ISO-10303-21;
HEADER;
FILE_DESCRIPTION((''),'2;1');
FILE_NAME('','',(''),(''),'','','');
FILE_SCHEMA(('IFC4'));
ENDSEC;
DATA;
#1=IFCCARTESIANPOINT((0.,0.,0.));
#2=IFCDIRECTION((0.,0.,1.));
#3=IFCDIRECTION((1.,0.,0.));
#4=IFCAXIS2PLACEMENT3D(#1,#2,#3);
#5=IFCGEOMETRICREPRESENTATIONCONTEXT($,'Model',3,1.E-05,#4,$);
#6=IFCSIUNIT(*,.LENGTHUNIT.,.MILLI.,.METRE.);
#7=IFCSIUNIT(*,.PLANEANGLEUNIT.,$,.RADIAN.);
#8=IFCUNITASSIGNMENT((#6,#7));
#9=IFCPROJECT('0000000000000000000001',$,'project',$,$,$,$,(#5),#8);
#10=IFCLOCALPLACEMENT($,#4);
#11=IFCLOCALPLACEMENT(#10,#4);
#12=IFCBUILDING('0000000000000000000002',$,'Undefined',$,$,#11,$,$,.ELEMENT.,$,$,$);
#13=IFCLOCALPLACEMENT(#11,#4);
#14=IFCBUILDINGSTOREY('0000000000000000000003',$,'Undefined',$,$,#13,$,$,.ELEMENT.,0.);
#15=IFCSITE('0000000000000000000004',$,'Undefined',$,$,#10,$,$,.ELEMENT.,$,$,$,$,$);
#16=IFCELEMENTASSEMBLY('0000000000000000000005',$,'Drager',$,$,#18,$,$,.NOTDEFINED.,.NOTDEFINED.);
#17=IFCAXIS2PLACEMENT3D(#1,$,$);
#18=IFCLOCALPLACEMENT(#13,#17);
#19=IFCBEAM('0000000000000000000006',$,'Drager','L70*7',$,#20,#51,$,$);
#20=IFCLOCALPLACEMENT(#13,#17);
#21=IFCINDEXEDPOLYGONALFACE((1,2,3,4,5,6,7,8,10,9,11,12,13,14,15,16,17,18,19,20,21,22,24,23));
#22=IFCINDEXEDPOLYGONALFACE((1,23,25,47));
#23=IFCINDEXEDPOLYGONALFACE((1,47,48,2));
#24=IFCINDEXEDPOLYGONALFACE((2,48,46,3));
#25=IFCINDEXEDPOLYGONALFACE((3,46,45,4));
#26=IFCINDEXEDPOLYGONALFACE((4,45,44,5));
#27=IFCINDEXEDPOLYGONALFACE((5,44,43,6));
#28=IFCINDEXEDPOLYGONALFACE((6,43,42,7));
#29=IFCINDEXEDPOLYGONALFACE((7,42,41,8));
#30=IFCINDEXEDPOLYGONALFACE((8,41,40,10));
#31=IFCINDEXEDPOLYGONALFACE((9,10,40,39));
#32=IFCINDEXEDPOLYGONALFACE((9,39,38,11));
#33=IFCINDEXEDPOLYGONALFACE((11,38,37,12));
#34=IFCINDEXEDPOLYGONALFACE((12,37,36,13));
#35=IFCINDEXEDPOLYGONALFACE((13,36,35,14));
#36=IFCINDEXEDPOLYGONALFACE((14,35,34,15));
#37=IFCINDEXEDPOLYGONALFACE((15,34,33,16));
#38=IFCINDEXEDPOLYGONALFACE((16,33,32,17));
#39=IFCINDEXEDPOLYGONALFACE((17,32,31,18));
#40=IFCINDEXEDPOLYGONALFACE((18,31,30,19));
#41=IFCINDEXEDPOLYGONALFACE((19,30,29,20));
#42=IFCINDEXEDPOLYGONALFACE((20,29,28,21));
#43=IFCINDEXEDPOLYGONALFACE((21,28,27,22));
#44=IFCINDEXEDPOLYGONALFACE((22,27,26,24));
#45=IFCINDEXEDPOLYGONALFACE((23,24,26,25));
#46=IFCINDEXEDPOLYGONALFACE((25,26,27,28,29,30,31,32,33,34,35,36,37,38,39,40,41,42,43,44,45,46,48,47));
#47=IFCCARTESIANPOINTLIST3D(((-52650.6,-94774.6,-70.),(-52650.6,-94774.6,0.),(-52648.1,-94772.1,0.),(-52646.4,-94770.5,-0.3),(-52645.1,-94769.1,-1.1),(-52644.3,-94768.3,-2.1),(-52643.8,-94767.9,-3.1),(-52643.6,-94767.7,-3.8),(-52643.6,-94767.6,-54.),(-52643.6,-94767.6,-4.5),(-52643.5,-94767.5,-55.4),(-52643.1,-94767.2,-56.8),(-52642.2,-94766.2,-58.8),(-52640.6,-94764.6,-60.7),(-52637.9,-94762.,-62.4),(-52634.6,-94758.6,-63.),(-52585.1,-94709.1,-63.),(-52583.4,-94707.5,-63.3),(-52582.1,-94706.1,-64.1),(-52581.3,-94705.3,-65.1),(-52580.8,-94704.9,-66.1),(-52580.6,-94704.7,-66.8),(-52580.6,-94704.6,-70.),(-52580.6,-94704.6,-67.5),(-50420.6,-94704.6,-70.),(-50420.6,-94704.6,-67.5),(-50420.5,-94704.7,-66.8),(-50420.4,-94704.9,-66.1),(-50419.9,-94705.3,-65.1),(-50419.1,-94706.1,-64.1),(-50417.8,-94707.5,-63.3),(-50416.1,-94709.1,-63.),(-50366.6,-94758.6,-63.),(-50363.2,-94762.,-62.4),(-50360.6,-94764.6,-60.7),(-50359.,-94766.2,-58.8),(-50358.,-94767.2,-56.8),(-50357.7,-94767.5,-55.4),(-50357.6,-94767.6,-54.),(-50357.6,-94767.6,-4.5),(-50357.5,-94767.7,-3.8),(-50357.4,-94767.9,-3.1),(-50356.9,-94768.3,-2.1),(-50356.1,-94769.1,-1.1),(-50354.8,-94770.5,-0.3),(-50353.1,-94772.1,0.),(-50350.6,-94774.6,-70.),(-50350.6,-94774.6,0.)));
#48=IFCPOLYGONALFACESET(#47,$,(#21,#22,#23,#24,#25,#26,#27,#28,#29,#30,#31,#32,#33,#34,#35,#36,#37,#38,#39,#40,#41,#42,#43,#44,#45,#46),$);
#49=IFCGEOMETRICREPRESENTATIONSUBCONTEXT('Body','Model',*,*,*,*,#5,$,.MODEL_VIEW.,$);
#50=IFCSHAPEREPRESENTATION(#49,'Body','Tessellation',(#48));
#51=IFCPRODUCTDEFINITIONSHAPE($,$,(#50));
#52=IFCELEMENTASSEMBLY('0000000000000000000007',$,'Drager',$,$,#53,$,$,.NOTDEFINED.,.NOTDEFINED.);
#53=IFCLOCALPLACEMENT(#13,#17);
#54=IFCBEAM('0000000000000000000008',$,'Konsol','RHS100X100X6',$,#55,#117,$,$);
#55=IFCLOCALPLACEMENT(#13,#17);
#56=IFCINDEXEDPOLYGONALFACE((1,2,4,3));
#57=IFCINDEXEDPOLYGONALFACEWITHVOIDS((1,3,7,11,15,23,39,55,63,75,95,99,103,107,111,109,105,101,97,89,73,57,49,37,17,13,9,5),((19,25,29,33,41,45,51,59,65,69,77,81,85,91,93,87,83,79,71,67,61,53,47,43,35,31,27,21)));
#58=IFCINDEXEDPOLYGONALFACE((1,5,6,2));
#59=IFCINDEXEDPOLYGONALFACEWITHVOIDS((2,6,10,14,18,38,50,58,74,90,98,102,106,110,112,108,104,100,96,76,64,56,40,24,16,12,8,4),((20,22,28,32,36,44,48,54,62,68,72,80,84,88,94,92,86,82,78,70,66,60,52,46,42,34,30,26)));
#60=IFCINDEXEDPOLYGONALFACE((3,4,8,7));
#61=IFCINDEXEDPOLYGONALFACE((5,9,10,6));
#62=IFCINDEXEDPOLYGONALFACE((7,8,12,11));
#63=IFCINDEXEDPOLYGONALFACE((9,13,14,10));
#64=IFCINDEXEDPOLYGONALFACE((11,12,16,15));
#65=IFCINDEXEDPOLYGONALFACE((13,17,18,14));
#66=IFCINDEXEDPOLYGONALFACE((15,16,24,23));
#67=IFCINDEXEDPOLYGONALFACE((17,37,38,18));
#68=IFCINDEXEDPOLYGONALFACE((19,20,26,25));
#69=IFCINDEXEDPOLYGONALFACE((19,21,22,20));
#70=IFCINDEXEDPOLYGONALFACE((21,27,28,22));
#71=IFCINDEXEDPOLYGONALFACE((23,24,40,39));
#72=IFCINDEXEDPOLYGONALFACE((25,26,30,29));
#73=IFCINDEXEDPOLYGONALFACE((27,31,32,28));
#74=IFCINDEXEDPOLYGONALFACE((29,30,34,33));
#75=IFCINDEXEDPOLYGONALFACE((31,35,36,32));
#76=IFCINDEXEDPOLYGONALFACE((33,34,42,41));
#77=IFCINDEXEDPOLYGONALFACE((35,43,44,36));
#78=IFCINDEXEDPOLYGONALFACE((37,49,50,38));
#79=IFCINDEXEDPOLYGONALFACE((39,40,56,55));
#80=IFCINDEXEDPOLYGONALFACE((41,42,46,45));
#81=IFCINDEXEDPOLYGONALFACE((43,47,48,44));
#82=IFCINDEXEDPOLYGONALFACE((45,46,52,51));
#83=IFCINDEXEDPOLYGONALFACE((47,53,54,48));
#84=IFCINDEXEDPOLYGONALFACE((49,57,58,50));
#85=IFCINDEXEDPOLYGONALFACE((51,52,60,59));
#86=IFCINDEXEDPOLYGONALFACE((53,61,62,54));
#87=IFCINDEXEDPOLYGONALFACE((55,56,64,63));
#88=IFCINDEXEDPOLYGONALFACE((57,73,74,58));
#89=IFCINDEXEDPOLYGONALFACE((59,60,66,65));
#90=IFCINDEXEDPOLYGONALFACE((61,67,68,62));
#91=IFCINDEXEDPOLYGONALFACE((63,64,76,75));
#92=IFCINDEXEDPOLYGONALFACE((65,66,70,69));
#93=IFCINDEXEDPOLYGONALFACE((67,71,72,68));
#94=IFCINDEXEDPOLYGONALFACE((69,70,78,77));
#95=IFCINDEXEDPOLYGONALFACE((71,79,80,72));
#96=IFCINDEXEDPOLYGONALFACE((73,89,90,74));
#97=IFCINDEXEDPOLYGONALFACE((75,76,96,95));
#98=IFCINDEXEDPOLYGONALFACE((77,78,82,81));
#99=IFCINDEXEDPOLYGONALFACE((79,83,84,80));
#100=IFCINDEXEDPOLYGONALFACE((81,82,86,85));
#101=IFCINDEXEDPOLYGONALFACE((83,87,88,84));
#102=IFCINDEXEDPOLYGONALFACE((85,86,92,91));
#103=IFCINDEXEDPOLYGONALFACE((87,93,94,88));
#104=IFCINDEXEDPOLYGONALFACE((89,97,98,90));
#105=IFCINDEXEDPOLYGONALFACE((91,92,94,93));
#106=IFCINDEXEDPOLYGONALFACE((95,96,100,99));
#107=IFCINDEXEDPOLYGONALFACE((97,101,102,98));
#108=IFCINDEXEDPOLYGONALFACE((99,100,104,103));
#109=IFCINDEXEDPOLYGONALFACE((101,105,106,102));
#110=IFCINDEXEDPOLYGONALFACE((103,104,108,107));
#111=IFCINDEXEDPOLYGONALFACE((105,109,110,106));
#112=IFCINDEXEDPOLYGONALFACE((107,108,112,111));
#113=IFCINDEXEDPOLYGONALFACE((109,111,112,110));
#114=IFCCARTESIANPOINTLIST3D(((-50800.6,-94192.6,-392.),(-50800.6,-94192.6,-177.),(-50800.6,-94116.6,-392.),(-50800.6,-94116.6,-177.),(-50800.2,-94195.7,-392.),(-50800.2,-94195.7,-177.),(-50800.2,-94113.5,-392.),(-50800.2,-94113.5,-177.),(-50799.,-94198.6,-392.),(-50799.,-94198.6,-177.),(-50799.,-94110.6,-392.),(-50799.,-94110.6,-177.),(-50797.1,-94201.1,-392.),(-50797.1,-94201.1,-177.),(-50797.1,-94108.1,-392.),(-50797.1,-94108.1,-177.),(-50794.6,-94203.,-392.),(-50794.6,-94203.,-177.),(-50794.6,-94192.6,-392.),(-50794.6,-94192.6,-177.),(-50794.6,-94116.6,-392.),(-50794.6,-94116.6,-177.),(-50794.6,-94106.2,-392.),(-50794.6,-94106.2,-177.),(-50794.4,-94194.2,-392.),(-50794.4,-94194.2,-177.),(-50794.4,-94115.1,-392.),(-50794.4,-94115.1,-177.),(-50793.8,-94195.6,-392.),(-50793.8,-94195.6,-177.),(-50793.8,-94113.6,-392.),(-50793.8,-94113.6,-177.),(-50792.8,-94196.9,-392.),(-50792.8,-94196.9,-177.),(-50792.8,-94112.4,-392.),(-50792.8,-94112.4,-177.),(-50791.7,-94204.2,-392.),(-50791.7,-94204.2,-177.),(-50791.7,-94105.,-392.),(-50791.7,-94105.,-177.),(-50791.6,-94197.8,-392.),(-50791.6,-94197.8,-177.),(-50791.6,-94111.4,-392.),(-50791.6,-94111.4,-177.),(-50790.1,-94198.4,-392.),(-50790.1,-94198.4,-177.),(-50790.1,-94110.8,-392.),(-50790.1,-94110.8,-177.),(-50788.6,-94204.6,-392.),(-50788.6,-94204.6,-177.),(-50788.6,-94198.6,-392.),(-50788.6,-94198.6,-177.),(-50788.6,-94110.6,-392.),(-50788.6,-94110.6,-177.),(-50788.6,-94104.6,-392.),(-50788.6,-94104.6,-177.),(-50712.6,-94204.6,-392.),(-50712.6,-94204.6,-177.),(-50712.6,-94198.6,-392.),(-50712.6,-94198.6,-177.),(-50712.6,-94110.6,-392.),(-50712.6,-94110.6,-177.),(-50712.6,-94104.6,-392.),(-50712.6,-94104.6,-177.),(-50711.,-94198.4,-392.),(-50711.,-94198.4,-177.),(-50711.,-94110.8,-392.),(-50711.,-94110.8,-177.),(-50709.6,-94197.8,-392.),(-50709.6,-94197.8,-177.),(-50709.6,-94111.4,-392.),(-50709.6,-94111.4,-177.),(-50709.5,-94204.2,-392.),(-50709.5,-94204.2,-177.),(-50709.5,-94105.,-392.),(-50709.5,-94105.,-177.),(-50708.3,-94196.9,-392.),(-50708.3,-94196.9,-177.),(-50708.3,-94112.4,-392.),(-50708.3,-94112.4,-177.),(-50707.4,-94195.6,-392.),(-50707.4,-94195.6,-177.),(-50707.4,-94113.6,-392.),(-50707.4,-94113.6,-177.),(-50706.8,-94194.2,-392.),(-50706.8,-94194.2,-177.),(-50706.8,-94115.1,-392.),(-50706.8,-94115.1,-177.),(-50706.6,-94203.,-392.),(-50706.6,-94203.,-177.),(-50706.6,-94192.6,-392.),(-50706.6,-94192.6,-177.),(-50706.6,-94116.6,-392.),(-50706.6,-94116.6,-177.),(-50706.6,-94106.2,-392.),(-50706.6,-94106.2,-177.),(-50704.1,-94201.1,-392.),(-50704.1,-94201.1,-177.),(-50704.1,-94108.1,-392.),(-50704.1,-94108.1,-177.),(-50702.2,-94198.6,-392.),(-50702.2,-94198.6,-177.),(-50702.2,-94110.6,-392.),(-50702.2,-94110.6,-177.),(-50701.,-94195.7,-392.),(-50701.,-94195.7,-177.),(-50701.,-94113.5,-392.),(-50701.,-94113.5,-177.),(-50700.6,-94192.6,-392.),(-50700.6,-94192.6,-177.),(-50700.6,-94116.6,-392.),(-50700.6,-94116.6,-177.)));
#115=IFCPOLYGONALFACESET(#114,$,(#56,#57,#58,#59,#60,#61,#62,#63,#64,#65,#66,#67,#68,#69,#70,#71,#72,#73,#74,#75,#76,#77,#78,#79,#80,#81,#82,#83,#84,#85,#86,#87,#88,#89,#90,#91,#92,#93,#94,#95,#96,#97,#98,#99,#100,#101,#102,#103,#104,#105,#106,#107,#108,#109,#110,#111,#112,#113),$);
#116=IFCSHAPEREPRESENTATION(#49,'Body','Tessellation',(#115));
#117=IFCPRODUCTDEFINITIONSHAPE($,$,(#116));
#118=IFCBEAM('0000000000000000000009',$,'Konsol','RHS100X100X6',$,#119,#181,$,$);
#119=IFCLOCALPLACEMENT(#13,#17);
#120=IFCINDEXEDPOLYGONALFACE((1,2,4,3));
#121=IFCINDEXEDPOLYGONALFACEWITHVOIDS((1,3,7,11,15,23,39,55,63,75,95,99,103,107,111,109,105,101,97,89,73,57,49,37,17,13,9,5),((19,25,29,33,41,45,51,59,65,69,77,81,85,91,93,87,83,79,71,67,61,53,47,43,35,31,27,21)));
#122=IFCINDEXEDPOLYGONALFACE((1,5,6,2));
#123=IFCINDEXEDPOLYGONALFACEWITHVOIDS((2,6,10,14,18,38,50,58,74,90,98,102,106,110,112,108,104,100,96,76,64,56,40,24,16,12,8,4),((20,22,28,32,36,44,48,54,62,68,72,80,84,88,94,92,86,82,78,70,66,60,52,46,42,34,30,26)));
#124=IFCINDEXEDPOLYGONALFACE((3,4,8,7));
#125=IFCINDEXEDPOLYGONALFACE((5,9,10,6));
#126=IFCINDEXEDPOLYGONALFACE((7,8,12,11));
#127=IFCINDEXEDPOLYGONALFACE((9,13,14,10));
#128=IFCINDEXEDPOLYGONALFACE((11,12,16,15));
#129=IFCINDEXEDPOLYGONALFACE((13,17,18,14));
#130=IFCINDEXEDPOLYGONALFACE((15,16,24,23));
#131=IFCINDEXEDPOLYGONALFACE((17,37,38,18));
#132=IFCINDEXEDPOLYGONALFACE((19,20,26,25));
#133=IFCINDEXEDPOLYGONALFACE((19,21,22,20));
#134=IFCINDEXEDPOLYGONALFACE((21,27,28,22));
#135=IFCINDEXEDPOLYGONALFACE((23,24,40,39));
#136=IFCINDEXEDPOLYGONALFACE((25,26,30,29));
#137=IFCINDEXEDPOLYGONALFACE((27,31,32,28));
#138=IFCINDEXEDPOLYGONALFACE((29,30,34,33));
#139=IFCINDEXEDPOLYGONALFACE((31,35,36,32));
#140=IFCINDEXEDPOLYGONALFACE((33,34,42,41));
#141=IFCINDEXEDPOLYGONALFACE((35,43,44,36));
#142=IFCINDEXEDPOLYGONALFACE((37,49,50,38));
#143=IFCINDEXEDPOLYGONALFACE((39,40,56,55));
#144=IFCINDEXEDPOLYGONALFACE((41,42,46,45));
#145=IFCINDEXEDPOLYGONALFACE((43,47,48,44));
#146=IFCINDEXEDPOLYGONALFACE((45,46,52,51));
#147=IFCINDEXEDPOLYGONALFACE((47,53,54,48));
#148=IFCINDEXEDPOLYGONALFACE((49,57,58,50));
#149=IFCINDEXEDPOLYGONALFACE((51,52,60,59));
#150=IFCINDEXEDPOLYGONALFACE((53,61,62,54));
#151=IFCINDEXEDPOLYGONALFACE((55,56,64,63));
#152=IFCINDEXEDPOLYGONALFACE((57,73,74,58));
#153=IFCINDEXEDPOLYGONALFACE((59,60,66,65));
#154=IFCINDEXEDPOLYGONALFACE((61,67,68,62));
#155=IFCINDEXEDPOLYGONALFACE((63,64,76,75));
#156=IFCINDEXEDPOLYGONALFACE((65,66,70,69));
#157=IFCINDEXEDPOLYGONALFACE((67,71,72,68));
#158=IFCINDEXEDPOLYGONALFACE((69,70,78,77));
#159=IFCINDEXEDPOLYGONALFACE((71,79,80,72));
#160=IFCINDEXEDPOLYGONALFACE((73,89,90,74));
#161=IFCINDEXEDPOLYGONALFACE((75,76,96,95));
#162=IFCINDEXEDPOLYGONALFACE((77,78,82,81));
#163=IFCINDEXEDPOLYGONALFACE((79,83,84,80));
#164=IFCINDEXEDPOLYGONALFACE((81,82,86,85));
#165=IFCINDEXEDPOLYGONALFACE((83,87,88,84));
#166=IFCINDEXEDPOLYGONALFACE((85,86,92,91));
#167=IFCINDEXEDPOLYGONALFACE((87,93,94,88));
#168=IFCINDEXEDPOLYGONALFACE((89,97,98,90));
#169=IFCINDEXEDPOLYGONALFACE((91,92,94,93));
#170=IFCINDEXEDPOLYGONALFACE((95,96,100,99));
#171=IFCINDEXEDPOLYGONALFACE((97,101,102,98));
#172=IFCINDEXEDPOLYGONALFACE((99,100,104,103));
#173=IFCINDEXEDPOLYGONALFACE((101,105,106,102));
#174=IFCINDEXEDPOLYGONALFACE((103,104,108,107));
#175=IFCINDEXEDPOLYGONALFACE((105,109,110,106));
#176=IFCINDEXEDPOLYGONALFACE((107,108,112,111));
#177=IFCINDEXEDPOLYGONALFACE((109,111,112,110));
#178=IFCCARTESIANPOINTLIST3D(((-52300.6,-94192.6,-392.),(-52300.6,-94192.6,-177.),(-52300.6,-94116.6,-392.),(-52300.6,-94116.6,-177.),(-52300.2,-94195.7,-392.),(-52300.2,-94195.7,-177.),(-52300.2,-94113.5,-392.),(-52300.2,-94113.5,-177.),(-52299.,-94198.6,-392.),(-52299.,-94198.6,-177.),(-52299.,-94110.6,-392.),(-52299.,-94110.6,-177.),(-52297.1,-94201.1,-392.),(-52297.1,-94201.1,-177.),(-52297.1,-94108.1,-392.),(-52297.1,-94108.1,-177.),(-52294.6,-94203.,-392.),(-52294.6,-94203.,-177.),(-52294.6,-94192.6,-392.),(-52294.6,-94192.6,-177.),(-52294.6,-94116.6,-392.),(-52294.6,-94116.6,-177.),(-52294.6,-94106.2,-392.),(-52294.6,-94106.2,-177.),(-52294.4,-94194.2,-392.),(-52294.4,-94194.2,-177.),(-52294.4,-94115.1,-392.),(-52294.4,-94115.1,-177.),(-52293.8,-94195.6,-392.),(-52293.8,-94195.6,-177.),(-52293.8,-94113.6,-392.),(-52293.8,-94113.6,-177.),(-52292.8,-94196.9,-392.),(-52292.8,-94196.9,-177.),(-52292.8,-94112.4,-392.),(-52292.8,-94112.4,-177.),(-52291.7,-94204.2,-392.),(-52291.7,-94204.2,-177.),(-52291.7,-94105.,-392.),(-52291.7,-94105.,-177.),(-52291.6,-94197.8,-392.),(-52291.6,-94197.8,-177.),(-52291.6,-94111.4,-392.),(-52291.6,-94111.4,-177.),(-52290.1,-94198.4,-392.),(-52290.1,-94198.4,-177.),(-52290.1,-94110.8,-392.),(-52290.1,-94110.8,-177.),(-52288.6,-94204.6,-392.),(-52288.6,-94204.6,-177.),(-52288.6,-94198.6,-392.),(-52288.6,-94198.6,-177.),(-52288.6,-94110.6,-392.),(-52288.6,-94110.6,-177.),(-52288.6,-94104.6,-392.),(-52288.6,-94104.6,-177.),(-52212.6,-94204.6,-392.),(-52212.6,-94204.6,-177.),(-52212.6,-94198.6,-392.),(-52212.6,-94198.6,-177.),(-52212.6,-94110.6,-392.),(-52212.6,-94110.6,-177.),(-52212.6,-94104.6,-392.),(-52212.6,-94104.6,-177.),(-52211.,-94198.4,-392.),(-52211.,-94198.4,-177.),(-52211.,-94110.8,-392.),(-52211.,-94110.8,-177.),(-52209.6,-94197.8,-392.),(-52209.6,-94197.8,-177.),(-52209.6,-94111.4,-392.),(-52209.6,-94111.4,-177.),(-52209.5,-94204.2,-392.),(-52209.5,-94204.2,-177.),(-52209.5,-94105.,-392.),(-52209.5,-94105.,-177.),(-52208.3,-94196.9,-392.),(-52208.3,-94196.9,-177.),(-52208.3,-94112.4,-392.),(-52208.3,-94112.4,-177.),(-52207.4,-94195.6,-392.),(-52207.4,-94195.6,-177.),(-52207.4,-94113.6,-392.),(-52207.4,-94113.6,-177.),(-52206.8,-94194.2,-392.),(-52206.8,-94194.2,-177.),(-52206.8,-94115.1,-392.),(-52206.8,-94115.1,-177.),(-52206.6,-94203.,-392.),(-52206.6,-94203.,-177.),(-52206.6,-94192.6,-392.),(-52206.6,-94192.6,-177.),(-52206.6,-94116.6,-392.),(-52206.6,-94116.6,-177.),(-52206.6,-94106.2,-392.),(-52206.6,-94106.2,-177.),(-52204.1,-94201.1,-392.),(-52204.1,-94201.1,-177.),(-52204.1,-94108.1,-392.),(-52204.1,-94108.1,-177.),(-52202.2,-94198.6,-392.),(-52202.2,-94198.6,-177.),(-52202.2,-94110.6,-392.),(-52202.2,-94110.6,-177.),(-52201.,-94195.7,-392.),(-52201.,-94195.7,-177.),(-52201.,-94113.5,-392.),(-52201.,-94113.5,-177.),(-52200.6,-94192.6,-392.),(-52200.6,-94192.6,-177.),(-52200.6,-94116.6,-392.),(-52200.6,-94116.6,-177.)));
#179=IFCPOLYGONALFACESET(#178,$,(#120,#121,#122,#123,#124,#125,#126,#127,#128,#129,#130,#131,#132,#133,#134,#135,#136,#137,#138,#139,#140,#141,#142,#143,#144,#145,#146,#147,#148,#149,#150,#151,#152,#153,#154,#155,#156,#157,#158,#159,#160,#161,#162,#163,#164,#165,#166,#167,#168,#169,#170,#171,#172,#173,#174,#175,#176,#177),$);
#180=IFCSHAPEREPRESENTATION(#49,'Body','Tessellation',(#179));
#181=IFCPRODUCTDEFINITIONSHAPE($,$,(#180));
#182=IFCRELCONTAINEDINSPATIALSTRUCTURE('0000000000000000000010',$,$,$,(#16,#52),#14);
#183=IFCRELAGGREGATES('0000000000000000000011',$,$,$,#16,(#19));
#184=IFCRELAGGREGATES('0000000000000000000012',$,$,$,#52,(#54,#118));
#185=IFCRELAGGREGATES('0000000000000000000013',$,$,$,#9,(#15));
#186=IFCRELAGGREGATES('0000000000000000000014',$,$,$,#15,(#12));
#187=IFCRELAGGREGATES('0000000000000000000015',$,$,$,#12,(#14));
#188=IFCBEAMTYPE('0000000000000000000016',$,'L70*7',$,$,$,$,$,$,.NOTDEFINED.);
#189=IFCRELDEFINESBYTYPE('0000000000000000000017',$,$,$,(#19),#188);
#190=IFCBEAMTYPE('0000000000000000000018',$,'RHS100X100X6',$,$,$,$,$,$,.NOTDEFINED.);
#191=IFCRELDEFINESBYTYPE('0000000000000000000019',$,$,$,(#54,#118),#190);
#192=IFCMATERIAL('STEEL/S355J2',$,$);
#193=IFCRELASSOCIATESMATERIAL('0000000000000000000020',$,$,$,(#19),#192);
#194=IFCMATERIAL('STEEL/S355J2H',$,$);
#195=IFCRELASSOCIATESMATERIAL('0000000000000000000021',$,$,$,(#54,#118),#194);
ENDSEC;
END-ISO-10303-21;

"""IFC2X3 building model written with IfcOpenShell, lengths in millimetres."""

from ifc_helpers import new_model, si_unit, frame, origin_with_axes, origin_2d_with_axis, place, context, subcontext, project, spatial, hollow_rectangle, l_section, extrude, clip, halfspace, material, type_object, element, aggregate, save


model = new_model("IFC2X3")

# Units and contexts
model_context = context("Model", 3, precision=1e-05, world=origin_with_axes())
body_context = subcontext(model_context, "Body", "Model", "MODEL_VIEW")
ifc_project = project(units=[si_unit("LENGTHUNIT", "METRE", prefix="MILLI"), si_unit("PLANEANGLEUNIT", "RADIAN")], contexts=[model_context])

# Site, building, storey
site_placement = place(None, origin_with_axes())
site = spatial("IfcSite", under=ifc_project, at=site_placement, Name="Undefined", CompositionType="ELEMENT")
building_placement = place(site_placement, origin_with_axes())
building = spatial("IfcBuilding", under=site, at=building_placement, Name="Undefined", CompositionType="ELEMENT")
storey_placement = place(building_placement, origin_with_axes())
storey = spatial("IfcBuildingStorey", under=building, at=storey_placement, Name="Undefined", CompositionType="ELEMENT", Elevation=0.0)

# Shared definitions
ifc_material_1 = material(Name="STEEL/S355J2")
beam_type_1 = type_object("IfcBeamType", Name="L70*7", PredefinedType="NOTDEFINED")

# Element assembly, beam
assembly_1_placement = place(storey_placement, origin_with_axes())
assembly_1 = element("IfcElementAssembly", 1, at=assembly_1_placement, inside=storey, Name="Drager", AssemblyPlace="NOTDEFINED", PredefinedType="NOTDEFINED")
beam_1_placement = place(assembly_1_placement, frame((-50420.6, -94739.6, -35.0), z_axis=(0.0, 0.0, 1.0), x_axis=(-1.0, 0.0, 0.0)))
beam_1 = element("IfcBeam", 2, at=beam_1_placement, type_object=beam_type_1, material=ifc_material_1, Name="Drager", Description="L70*7", context=body_context, shape_type="Clipping", body=[
    clip(clip(extrude(l_section(Depth=70.0, Width=70.0, Thickness=7.0, FilletRadius=9.0, EdgeRadius=4.5, at=origin_2d_with_axis()), frame((2265.7, 0.0, 0.0), z_axis=(-1.0, 0.0, 0.0), x_axis=(0.0, -1.0, 0.0)), (0.0, 0.0, 1.0), 2371.4), halfspace(frame((2160.0, -35.0, 35.0), z_axis=(0.707107, -0.707107, 0.0), x_axis=(0.0, 0.0, 1.0)), False)), halfspace(frame((0.0, -35.0, 35.0), z_axis=(0.707107, 0.707107, 0.0), x_axis=(0.0, 0.0, 1.0)), True)),
])
aggregate(assembly_1, [beam_1])

# Element assembly, beams
assembly_2_placement = place(storey_placement, origin_with_axes())
assembly_2 = element("IfcElementAssembly", 3, at=assembly_2_placement, inside=storey, Name="Drager", AssemblyPlace="NOTDEFINED", PredefinedType="NOTDEFINED")
ifc_material_2 = material(Name="STEEL/S355J2H")
beam_type_2 = type_object("IfcBeamType", Name="RHS100X100X6", PredefinedType="NOTDEFINED")
beam_2_placement = place(assembly_2_placement, frame((-50750.6, -94154.6, -177.0), z_axis=(1.0, 0.0, 0.0), x_axis=(0.0, 0.0, -1.0)))
beam_2 = element("IfcBeam", 4, at=beam_2_placement, type_object=beam_type_2, material=ifc_material_2, Name="Konsol", Description="RHS100X100X6", context=body_context, shape_type="Clipping", body=[
    clip(extrude(hollow_rectangle(XDim=100.0, YDim=100.0, WallThickness=6.0, InnerFilletRadius=6.0, OuterFilletRadius=12.0, at=origin_2d_with_axis()), frame((223.0, 0.0, 0.0), z_axis=(-1.0, 0.0, 0.0), x_axis=(0.0, -1.0, 0.0)), (0.0, 0.0, 1.0), 223.0), halfspace(frame((215.0, 0.0, -50.0), z_axis=(-1.0, 0.0, 0.0), x_axis=(0.0, 1.0, 0.0)), True)),
])
beam_3_placement = place(assembly_2_placement, frame((-52250.6, -94154.6, -177.0), z_axis=(1.0, 0.0, 0.0), x_axis=(0.0, 0.0, -1.0)))
beam_3 = element("IfcBeam", 5, at=beam_3_placement, type_object=beam_type_2, material=ifc_material_2, Name="Konsol", Description="RHS100X100X6", context=body_context, shape_type="Clipping", body=[
    clip(extrude(hollow_rectangle(XDim=100.0, YDim=100.0, WallThickness=6.0, InnerFilletRadius=6.0, OuterFilletRadius=12.0, at=origin_2d_with_axis()), frame((223.0, 0.0, 0.0), z_axis=(-1.0, 0.0, 0.0), x_axis=(0.0, -1.0, 0.0)), (0.0, 0.0, 1.0), 223.0), halfspace(frame((215.0, 0.0, -50.0), z_axis=(-1.0, 0.0, 0.0), x_axis=(0.0, 1.0, 0.0)), True)),
])

aggregate(assembly_2, [beam_2, beam_3])

save(model, "model.ifc")
